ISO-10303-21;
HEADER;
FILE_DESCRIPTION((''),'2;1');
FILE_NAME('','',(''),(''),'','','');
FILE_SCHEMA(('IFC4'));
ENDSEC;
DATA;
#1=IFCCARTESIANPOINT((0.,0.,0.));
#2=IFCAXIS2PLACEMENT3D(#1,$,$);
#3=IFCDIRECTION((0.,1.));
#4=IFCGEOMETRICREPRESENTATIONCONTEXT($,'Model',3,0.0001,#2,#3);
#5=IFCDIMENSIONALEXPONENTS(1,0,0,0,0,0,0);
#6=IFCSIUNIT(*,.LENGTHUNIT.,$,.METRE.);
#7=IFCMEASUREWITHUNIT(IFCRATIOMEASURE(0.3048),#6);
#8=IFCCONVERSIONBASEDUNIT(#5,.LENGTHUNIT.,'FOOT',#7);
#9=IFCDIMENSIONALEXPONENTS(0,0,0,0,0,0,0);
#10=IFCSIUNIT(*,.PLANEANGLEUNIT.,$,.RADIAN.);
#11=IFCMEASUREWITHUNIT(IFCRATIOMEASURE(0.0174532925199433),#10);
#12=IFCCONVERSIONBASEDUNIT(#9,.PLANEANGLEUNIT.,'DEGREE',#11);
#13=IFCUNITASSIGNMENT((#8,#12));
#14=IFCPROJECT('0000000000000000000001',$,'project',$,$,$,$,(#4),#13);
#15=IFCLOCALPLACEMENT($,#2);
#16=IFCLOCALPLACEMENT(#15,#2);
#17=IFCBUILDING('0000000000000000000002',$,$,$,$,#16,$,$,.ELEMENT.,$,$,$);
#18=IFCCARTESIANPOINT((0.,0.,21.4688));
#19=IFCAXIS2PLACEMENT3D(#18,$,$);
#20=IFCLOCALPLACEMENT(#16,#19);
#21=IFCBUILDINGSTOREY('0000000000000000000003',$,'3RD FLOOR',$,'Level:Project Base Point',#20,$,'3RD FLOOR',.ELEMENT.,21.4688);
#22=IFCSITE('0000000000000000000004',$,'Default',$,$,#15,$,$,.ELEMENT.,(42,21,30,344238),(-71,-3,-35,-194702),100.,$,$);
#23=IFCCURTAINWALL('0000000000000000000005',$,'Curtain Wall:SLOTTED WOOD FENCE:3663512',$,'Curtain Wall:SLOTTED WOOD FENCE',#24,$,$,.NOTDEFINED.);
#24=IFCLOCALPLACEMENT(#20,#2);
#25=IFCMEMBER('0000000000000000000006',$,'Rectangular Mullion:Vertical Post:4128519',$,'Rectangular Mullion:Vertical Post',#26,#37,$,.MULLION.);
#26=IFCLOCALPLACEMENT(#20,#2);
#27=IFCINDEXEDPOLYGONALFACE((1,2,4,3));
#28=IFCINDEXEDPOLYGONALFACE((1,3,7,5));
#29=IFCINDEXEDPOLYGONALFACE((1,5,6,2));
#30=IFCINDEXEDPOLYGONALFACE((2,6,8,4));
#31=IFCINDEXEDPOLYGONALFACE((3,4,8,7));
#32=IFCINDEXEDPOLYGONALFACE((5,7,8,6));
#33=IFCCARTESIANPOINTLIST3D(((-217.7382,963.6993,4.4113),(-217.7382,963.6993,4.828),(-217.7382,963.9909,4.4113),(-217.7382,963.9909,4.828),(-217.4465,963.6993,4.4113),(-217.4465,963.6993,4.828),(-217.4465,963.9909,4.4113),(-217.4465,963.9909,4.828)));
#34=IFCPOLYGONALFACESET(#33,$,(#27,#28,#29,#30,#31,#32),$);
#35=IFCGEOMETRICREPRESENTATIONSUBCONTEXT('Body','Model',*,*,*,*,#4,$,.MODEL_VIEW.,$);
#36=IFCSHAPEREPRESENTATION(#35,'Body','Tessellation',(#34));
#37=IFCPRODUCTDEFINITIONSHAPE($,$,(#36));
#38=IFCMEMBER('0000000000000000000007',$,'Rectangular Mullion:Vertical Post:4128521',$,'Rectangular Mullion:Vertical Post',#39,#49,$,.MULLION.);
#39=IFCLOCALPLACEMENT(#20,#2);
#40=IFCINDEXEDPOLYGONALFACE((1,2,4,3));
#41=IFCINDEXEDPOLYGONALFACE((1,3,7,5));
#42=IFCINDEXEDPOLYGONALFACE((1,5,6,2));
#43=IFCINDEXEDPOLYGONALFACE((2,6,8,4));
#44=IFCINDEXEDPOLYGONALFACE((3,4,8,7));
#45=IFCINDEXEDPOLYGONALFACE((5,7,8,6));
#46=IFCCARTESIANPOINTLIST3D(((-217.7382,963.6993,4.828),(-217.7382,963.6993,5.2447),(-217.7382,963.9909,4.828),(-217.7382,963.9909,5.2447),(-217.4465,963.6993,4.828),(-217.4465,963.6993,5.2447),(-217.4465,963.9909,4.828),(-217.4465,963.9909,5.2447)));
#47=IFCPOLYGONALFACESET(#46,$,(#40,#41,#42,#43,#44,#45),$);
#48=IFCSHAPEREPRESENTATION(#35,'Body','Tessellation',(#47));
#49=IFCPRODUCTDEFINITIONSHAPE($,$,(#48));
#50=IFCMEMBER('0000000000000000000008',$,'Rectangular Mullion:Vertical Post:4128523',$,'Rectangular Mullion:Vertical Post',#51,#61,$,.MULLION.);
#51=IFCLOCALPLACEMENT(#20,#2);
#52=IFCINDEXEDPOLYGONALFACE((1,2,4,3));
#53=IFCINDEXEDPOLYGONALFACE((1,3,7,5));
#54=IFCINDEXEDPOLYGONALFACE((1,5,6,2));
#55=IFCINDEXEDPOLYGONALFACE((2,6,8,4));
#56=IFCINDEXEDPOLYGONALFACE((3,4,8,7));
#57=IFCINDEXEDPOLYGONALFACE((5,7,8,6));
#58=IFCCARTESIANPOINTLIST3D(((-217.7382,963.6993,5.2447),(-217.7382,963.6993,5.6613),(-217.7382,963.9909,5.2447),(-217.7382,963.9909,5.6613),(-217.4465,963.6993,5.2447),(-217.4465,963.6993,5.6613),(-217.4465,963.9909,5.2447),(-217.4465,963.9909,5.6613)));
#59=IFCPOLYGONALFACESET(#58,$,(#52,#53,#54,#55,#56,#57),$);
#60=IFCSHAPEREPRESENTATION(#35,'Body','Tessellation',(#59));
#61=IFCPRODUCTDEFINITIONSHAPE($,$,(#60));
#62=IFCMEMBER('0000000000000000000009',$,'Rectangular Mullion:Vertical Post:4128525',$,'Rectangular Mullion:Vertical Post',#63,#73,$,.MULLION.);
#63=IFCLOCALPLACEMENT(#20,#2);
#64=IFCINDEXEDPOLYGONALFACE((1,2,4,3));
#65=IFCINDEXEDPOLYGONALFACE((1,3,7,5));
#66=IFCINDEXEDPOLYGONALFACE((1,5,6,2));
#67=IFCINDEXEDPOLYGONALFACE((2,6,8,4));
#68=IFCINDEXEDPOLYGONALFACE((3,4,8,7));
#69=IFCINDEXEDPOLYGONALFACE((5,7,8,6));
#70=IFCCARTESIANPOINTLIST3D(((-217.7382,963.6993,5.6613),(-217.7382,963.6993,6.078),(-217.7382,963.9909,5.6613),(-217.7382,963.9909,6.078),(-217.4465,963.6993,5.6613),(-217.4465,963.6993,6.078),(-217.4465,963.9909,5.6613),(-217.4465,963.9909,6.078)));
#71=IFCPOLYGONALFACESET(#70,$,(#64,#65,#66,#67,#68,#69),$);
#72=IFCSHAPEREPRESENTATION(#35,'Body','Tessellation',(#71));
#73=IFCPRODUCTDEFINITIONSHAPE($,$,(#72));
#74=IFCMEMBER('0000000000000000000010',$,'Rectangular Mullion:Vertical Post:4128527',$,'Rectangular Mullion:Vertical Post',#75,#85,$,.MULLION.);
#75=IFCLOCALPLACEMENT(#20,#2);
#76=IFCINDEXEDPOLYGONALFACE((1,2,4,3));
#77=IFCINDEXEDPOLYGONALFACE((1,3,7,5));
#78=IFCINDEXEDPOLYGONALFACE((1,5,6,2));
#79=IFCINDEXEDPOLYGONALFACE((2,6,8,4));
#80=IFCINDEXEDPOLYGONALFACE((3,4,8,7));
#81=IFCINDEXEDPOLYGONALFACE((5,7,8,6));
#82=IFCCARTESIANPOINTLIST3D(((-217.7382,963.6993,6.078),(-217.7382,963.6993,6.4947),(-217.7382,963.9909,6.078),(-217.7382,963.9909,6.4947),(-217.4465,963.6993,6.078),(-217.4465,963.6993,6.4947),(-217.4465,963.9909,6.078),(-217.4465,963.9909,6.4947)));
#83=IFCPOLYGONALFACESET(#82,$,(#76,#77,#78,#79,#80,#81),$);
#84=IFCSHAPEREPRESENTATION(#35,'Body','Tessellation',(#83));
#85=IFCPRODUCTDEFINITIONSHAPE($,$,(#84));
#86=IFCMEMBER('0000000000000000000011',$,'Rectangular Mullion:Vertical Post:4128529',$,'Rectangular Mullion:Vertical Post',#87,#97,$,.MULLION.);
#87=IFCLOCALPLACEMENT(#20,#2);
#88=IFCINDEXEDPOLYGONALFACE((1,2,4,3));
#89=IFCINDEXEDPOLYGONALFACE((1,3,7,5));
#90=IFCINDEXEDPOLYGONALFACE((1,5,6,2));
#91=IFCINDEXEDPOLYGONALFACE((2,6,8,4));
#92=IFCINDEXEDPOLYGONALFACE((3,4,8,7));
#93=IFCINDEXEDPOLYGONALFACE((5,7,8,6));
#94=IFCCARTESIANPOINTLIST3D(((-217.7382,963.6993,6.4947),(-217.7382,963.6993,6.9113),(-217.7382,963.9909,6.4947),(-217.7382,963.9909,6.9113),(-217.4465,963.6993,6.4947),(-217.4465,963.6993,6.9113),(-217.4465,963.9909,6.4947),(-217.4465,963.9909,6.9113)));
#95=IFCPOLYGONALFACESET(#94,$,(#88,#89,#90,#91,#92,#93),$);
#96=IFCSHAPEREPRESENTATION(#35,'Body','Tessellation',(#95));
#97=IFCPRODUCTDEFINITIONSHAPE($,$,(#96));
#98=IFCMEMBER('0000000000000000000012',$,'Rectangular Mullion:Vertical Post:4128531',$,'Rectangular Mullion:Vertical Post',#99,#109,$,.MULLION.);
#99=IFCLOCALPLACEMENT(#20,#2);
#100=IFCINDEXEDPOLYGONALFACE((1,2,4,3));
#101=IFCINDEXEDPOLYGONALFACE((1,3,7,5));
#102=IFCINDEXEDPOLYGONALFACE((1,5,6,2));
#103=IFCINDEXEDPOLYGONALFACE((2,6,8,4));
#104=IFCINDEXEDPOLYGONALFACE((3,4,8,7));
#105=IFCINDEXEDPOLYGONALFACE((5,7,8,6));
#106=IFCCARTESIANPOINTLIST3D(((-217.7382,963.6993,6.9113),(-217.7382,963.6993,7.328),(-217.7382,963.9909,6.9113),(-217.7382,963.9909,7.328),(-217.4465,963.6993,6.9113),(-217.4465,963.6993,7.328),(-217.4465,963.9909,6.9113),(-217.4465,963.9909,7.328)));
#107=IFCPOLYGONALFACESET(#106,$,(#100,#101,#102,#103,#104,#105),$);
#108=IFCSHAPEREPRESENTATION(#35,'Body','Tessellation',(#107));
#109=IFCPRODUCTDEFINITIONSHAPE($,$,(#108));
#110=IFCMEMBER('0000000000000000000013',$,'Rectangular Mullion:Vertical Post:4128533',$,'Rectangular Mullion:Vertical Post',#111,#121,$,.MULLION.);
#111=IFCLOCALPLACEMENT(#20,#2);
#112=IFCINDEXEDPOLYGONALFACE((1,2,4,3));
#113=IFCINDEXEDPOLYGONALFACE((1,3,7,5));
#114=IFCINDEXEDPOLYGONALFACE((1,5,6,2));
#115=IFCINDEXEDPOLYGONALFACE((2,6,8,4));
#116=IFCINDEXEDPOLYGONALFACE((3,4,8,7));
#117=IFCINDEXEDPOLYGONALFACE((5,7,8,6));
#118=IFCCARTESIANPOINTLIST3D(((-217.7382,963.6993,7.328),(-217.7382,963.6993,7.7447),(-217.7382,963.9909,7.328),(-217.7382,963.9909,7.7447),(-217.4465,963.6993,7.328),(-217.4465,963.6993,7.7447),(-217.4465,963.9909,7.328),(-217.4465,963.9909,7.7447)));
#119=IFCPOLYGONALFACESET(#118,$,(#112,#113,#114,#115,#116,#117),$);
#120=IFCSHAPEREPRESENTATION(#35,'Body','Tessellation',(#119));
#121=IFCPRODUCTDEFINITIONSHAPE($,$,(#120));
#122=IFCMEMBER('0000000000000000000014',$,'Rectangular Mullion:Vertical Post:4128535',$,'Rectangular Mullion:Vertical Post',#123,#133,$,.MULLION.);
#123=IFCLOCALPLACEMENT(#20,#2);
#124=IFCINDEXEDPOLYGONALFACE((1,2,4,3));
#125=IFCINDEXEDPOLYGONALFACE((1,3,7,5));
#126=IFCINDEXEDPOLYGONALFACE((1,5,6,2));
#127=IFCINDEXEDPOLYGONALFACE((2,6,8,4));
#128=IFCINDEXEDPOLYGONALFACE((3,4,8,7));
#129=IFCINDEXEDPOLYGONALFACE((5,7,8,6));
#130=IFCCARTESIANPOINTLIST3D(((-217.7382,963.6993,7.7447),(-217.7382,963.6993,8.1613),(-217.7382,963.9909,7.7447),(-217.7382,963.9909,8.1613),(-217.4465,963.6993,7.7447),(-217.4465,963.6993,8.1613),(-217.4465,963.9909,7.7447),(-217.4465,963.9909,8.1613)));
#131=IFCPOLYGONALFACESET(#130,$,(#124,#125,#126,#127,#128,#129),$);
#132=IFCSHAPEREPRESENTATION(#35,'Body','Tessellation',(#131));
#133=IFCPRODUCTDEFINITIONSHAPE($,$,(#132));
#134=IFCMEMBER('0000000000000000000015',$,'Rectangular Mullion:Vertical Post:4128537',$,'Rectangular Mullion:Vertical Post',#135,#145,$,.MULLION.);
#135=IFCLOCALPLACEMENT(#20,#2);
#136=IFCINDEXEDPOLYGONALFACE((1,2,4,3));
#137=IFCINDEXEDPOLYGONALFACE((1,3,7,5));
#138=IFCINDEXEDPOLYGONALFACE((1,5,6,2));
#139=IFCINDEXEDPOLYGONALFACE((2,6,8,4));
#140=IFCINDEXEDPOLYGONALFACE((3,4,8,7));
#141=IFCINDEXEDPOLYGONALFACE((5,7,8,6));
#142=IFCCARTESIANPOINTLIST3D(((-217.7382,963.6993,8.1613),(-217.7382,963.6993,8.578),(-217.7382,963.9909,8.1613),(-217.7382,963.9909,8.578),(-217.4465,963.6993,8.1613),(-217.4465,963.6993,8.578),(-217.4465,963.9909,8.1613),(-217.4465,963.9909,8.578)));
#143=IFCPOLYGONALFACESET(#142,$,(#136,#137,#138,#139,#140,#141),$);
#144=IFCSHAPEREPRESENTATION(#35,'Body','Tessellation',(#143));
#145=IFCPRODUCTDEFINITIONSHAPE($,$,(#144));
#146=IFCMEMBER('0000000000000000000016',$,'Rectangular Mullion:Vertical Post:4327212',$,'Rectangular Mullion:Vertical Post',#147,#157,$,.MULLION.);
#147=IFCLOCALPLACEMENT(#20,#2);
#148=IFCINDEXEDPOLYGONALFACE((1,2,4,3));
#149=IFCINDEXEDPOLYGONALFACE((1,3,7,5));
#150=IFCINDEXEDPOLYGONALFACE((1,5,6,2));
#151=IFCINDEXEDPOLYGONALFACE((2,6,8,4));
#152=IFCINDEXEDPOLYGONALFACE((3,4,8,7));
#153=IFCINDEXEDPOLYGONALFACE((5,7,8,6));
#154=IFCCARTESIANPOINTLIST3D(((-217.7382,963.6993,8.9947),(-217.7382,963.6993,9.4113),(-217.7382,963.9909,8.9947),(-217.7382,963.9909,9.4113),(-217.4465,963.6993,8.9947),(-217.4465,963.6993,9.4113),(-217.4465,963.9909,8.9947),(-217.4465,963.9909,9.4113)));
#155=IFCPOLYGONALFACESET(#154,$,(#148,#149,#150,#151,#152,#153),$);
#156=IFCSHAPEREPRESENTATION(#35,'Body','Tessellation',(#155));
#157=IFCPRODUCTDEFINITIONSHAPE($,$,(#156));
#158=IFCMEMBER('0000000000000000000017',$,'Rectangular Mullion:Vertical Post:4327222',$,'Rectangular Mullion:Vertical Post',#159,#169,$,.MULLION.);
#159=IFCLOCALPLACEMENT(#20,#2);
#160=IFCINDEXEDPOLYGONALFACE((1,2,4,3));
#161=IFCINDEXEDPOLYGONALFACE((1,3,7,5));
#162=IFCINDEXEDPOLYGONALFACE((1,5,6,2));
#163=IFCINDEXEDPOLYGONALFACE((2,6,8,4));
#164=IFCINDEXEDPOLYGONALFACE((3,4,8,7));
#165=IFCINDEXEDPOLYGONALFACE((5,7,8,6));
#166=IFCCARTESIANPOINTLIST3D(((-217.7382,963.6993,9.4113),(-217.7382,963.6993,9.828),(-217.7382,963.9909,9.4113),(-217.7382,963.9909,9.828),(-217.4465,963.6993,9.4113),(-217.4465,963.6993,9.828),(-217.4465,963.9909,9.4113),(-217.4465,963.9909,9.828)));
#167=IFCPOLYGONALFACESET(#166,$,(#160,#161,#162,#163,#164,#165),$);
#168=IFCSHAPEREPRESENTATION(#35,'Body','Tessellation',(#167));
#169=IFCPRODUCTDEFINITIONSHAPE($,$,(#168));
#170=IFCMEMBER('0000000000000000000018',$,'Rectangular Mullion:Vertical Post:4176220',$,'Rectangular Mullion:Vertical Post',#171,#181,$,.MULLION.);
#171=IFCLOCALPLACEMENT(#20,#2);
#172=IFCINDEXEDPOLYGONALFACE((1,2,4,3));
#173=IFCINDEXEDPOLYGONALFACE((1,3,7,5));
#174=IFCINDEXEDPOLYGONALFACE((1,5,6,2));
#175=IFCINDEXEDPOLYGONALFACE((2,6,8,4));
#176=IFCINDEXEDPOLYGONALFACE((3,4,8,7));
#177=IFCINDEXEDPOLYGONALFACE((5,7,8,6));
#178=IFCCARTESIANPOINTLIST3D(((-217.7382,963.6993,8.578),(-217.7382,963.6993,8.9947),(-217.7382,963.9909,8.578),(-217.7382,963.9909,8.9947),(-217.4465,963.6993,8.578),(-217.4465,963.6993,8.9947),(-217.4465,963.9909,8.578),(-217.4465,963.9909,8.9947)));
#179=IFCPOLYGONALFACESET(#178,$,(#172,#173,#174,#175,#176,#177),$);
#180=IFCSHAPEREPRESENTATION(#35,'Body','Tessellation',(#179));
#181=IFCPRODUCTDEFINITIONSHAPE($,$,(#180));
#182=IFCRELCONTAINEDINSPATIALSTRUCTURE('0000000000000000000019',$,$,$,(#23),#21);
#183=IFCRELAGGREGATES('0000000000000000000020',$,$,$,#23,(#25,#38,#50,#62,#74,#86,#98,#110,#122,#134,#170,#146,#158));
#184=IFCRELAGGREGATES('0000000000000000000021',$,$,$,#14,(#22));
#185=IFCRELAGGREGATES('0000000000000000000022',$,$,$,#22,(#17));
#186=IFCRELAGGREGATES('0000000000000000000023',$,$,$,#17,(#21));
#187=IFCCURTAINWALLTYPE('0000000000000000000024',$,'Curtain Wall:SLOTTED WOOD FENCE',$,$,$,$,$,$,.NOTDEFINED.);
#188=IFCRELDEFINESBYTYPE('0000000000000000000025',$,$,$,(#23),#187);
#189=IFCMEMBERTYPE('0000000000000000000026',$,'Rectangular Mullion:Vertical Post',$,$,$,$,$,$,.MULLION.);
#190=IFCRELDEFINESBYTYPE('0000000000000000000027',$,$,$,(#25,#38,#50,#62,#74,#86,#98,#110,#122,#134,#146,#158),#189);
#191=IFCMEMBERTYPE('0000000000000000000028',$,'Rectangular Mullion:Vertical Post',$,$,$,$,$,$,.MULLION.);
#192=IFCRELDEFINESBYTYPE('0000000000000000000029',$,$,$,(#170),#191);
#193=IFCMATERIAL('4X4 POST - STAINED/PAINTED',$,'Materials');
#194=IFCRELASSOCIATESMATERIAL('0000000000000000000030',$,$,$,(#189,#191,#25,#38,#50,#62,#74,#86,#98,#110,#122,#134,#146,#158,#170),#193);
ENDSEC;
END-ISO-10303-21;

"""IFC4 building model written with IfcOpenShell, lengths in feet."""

from ifc_helpers import new_model, entity, si_unit, converted_unit, direction, frame, origin, origin_2d_with_axis, place, context, subcontext, project, spatial, rectangle, extrude, source, transform, mapped, material, material_profile, profile_set, profile_usage, type_object, type_shapes, element, aggregate, save


model = new_model("IFC4")

# Units and contexts
model_context = context("Model", 3, precision=0.0001, world=origin(), true_north=direction((0.0, 1.0)))
body_context = subcontext(model_context, "Body", "Model", "MODEL_VIEW")
ifc_project = project(units=[converted_unit("LENGTHUNIT", "FOOT", entity("IfcRatioMeasure", 0.3048), si_unit("LENGTHUNIT", "METRE"), dimensions=[1, 0, 0, 0, 0, 0, 0]), converted_unit("PLANEANGLEUNIT", "DEGREE", entity("IfcRatioMeasure", 0.0174532925199433), si_unit("PLANEANGLEUNIT", "RADIAN"), dimensions=[0, 0, 0, 0, 0, 0, 0])], contexts=[model_context])

# Site, building, storey
site_placement = place(None, origin())
site = spatial("IfcSite", under=ifc_project, at=site_placement, Name="Default", CompositionType="ELEMENT", RefLatitude=(42, 21, 30, 344238), RefLongitude=(-71, -3, -35, -194702), RefElevation=100.0)
building_placement = place(site_placement, origin())
building = spatial("IfcBuilding", under=site, at=building_placement, CompositionType="ELEMENT")
storey_placement = place(building_placement, frame((0.0, 0.0, 21.4688)))
storey = spatial("IfcBuildingStorey", under=building, at=storey_placement, Name="3RD FLOOR", ObjectType="Level:Project Base Point", LongName="3RD FLOOR", CompositionType="ELEMENT", Elevation=21.4688)

# Curtain wall, members
curtain_wall_type = type_object("IfcCurtainWallType", Name="Curtain Wall:SLOTTED WOOD FENCE", PredefinedType="NOTDEFINED")
curtain_wall_1_placement = place(storey_placement, frame((0.0, 0.0, -21.4688)))
curtain_wall_1 = element("IfcCurtainWall", 1, at=curtain_wall_1_placement, inside=storey, type_object=curtain_wall_type, Name="Curtain Wall:SLOTTED WOOD FENCE:3663512", ObjectType="Curtain Wall:SLOTTED WOOD FENCE", PredefinedType="NOTDEFINED")
ifc_material_1 = material(Name="4X4 POST - STAINED/PAINTED", Category="Materials")
ifc_material_profile = material_profile(ifc_material_1, rectangle(XDim=0.2917, YDim=0.2917, at=origin_2d_with_axis()), Name="Vertical Post")
ifc_profile_set = profile_set([ifc_material_profile], Name="Vertical Post")
ifc_profile_usage_1 = profile_usage(ifc_profile_set)
member_type_1 = type_object("IfcMemberType", Name="Rectangular Mullion:Vertical Post", PredefinedType="MULLION", material=ifc_profile_set)
shared_shape_1 = source(origin(), body_context, "Body", "SweptSolid", [
    extrude(rectangle(XDim=0.2917, YDim=0.2917, at=origin_2d_with_axis()), frame((0.0, -0.2083, -0.4167), z_axis=(0.0, 0.0, 1.0), x_axis=(0.0, -1.0, 0.0)), (0.0, 0.0, 1.0), 0.4167),
])
type_shapes(member_type_1, [shared_shape_1])
member_1_placement = place(storey_placement, frame((-217.8007, 963.8451, 4.4113), z_axis=(0.0, 0.0, -1.0), x_axis=(0.0, -1.0, 0.0)))
member_1 = element("IfcMember", 2, at=member_1_placement, type_object=member_type_1, material=ifc_profile_usage_1, Name="Rectangular Mullion:Vertical Post:4128519", ObjectType="Rectangular Mullion:Vertical Post", PredefinedType="MULLION", context=body_context, shape_type="MappedRepresentation", body=[
    mapped(shared_shape_1, transform((0.0, 0.0, 0.0), scale=1.0)),
])
ifc_profile_usage_2 = profile_usage(ifc_profile_set)
member_2_placement = place(storey_placement, frame((-217.8007, 963.8451, 4.828), z_axis=(0.0, 0.0, -1.0), x_axis=(0.0, -1.0, 0.0)))
member_2 = element("IfcMember", 3, at=member_2_placement, type_object=member_type_1, material=ifc_profile_usage_2, Name="Rectangular Mullion:Vertical Post:4128521", ObjectType="Rectangular Mullion:Vertical Post", PredefinedType="MULLION", context=body_context, shape_type="MappedRepresentation", body=[
    mapped(shared_shape_1, transform((0.0, 0.0, 0.0), scale=1.0)),
])
ifc_profile_usage_3 = profile_usage(ifc_profile_set)
member_3_placement = place(storey_placement, frame((-217.8007, 963.8451, 5.2447), z_axis=(0.0, 0.0, -1.0), x_axis=(0.0, -1.0, 0.0)))
member_3 = element("IfcMember", 4, at=member_3_placement, type_object=member_type_1, material=ifc_profile_usage_3, Name="Rectangular Mullion:Vertical Post:4128523", ObjectType="Rectangular Mullion:Vertical Post", PredefinedType="MULLION", context=body_context, shape_type="MappedRepresentation", body=[
    mapped(shared_shape_1, transform((0.0, 0.0, 0.0), scale=1.0)),
])
ifc_profile_usage_4 = profile_usage(ifc_profile_set)
member_4_placement = place(storey_placement, frame((-217.8007, 963.8451, 5.6613), z_axis=(0.0, 0.0, -1.0), x_axis=(0.0, -1.0, 0.0)))
member_4 = element("IfcMember", 5, at=member_4_placement, type_object=member_type_1, material=ifc_profile_usage_4, Name="Rectangular Mullion:Vertical Post:4128525", ObjectType="Rectangular Mullion:Vertical Post", PredefinedType="MULLION", context=body_context, shape_type="MappedRepresentation", body=[
    mapped(shared_shape_1, transform((0.0, 0.0, 0.0), scale=1.0)),
])
ifc_profile_usage_5 = profile_usage(ifc_profile_set)
member_5_placement = place(storey_placement, frame((-217.8007, 963.8451, 6.078), z_axis=(0.0, 0.0, -1.0), x_axis=(0.0, -1.0, 0.0)))
member_5 = element("IfcMember", 6, at=member_5_placement, type_object=member_type_1, material=ifc_profile_usage_5, Name="Rectangular Mullion:Vertical Post:4128527", ObjectType="Rectangular Mullion:Vertical Post", PredefinedType="MULLION", context=body_context, shape_type="MappedRepresentation", body=[
    mapped(shared_shape_1, transform((0.0, 0.0, 0.0), scale=1.0)),
])
ifc_profile_usage_6 = profile_usage(ifc_profile_set)
member_6_placement = place(storey_placement, frame((-217.8007, 963.8451, 6.4947), z_axis=(0.0, 0.0, -1.0), x_axis=(0.0, -1.0, 0.0)))
member_6 = element("IfcMember", 7, at=member_6_placement, type_object=member_type_1, material=ifc_profile_usage_6, Name="Rectangular Mullion:Vertical Post:4128529", ObjectType="Rectangular Mullion:Vertical Post", PredefinedType="MULLION", context=body_context, shape_type="MappedRepresentation", body=[
    mapped(shared_shape_1, transform((0.0, 0.0, 0.0), scale=1.0)),
])
ifc_profile_usage_7 = profile_usage(ifc_profile_set)
member_7_placement = place(storey_placement, frame((-217.8007, 963.8451, 6.9113), z_axis=(0.0, 0.0, -1.0), x_axis=(0.0, -1.0, 0.0)))
member_7 = element("IfcMember", 8, at=member_7_placement, type_object=member_type_1, material=ifc_profile_usage_7, Name="Rectangular Mullion:Vertical Post:4128531", ObjectType="Rectangular Mullion:Vertical Post", PredefinedType="MULLION", context=body_context, shape_type="MappedRepresentation", body=[
    mapped(shared_shape_1, transform((0.0, 0.0, 0.0), scale=1.0)),
])
ifc_profile_usage_8 = profile_usage(ifc_profile_set)
member_8_placement = place(storey_placement, frame((-217.8007, 963.8451, 7.328), z_axis=(0.0, 0.0, -1.0), x_axis=(0.0, -1.0, 0.0)))
member_8 = element("IfcMember", 9, at=member_8_placement, type_object=member_type_1, material=ifc_profile_usage_8, Name="Rectangular Mullion:Vertical Post:4128533", ObjectType="Rectangular Mullion:Vertical Post", PredefinedType="MULLION", context=body_context, shape_type="MappedRepresentation", body=[
    mapped(shared_shape_1, transform((0.0, 0.0, 0.0), scale=1.0)),
])
ifc_profile_usage_9 = profile_usage(ifc_profile_set)
member_9_placement = place(storey_placement, frame((-217.8007, 963.8451, 7.7447), z_axis=(0.0, 0.0, -1.0), x_axis=(0.0, -1.0, 0.0)))
member_9 = element("IfcMember", 10, at=member_9_placement, type_object=member_type_1, material=ifc_profile_usage_9, Name="Rectangular Mullion:Vertical Post:4128535", ObjectType="Rectangular Mullion:Vertical Post", PredefinedType="MULLION", context=body_context, shape_type="MappedRepresentation", body=[
    mapped(shared_shape_1, transform((0.0, 0.0, 0.0), scale=1.0)),
])
ifc_profile_usage_10 = profile_usage(ifc_profile_set)
member_10_placement = place(storey_placement, frame((-217.8007, 963.8451, 8.1613), z_axis=(0.0, 0.0, -1.0), x_axis=(0.0, -1.0, 0.0)))
member_10 = element("IfcMember", 11, at=member_10_placement, type_object=member_type_1, material=ifc_profile_usage_10, Name="Rectangular Mullion:Vertical Post:4128537", ObjectType="Rectangular Mullion:Vertical Post", PredefinedType="MULLION", context=body_context, shape_type="MappedRepresentation", body=[
    mapped(shared_shape_1, transform((0.0, 0.0, 0.0), scale=1.0)),
])
ifc_profile_usage_11 = profile_usage(ifc_profile_set)
member_11_placement = place(storey_placement, frame((-217.8007, 963.8451, 8.9947), z_axis=(0.0, 0.0, -1.0), x_axis=(0.0, -1.0, 0.0)))
member_11 = element("IfcMember", 12, at=member_11_placement, type_object=member_type_1, material=ifc_profile_usage_11, Name="Rectangular Mullion:Vertical Post:4327212", ObjectType="Rectangular Mullion:Vertical Post", PredefinedType="MULLION", context=body_context, shape_type="MappedRepresentation", body=[
    mapped(shared_shape_1, transform((0.0, 0.0, 0.0), scale=1.0)),
])
ifc_profile_usage_12 = profile_usage(ifc_profile_set)
member_12_placement = place(storey_placement, frame((-217.8007, 963.8451, 9.4113), z_axis=(0.0, 0.0, -1.0), x_axis=(0.0, -1.0, 0.0)))
member_12 = element("IfcMember", 13, at=member_12_placement, type_object=member_type_1, material=ifc_profile_usage_12, Name="Rectangular Mullion:Vertical Post:4327222", ObjectType="Rectangular Mullion:Vertical Post", PredefinedType="MULLION", context=body_context, shape_type="MappedRepresentation", body=[
    mapped(shared_shape_1, transform((0.0, 0.0, 0.0), scale=1.0)),
])
ifc_profile_usage_13 = profile_usage(ifc_profile_set)
member_type_2 = type_object("IfcMemberType", Name="Rectangular Mullion:Vertical Post", PredefinedType="MULLION", material=ifc_profile_set)
shared_shape_2 = source(origin(), body_context, "Body", "SweptSolid", [
    extrude(rectangle(XDim=0.2917, YDim=0.2917, at=origin_2d_with_axis()), frame((0.0, -0.2083, -0.4167), z_axis=(0.0, 0.0, 1.0), x_axis=(0.0, -1.0, 0.0)), (0.0, 0.0, 1.0), 0.4167),
])
type_shapes(member_type_2, [shared_shape_2])
member_13_placement = place(storey_placement, frame((-217.8007, 963.8451, 8.578), z_axis=(0.0, 0.0, -1.0), x_axis=(0.0, -1.0, 0.0)))
member_13 = element("IfcMember", 14, at=member_13_placement, type_object=member_type_2, material=ifc_profile_usage_13, Name="Rectangular Mullion:Vertical Post:4176220", ObjectType="Rectangular Mullion:Vertical Post", PredefinedType="MULLION", context=body_context, shape_type="MappedRepresentation", body=[
    mapped(shared_shape_2, transform((0.0, 0.0, 0.0), scale=1.0)),
])
aggregate(curtain_wall_1, [member_1, member_2, member_3, member_4, member_5, member_6, member_7, member_8, member_9, member_10, member_13, member_11, member_12])

save(model, "model.ifc")
